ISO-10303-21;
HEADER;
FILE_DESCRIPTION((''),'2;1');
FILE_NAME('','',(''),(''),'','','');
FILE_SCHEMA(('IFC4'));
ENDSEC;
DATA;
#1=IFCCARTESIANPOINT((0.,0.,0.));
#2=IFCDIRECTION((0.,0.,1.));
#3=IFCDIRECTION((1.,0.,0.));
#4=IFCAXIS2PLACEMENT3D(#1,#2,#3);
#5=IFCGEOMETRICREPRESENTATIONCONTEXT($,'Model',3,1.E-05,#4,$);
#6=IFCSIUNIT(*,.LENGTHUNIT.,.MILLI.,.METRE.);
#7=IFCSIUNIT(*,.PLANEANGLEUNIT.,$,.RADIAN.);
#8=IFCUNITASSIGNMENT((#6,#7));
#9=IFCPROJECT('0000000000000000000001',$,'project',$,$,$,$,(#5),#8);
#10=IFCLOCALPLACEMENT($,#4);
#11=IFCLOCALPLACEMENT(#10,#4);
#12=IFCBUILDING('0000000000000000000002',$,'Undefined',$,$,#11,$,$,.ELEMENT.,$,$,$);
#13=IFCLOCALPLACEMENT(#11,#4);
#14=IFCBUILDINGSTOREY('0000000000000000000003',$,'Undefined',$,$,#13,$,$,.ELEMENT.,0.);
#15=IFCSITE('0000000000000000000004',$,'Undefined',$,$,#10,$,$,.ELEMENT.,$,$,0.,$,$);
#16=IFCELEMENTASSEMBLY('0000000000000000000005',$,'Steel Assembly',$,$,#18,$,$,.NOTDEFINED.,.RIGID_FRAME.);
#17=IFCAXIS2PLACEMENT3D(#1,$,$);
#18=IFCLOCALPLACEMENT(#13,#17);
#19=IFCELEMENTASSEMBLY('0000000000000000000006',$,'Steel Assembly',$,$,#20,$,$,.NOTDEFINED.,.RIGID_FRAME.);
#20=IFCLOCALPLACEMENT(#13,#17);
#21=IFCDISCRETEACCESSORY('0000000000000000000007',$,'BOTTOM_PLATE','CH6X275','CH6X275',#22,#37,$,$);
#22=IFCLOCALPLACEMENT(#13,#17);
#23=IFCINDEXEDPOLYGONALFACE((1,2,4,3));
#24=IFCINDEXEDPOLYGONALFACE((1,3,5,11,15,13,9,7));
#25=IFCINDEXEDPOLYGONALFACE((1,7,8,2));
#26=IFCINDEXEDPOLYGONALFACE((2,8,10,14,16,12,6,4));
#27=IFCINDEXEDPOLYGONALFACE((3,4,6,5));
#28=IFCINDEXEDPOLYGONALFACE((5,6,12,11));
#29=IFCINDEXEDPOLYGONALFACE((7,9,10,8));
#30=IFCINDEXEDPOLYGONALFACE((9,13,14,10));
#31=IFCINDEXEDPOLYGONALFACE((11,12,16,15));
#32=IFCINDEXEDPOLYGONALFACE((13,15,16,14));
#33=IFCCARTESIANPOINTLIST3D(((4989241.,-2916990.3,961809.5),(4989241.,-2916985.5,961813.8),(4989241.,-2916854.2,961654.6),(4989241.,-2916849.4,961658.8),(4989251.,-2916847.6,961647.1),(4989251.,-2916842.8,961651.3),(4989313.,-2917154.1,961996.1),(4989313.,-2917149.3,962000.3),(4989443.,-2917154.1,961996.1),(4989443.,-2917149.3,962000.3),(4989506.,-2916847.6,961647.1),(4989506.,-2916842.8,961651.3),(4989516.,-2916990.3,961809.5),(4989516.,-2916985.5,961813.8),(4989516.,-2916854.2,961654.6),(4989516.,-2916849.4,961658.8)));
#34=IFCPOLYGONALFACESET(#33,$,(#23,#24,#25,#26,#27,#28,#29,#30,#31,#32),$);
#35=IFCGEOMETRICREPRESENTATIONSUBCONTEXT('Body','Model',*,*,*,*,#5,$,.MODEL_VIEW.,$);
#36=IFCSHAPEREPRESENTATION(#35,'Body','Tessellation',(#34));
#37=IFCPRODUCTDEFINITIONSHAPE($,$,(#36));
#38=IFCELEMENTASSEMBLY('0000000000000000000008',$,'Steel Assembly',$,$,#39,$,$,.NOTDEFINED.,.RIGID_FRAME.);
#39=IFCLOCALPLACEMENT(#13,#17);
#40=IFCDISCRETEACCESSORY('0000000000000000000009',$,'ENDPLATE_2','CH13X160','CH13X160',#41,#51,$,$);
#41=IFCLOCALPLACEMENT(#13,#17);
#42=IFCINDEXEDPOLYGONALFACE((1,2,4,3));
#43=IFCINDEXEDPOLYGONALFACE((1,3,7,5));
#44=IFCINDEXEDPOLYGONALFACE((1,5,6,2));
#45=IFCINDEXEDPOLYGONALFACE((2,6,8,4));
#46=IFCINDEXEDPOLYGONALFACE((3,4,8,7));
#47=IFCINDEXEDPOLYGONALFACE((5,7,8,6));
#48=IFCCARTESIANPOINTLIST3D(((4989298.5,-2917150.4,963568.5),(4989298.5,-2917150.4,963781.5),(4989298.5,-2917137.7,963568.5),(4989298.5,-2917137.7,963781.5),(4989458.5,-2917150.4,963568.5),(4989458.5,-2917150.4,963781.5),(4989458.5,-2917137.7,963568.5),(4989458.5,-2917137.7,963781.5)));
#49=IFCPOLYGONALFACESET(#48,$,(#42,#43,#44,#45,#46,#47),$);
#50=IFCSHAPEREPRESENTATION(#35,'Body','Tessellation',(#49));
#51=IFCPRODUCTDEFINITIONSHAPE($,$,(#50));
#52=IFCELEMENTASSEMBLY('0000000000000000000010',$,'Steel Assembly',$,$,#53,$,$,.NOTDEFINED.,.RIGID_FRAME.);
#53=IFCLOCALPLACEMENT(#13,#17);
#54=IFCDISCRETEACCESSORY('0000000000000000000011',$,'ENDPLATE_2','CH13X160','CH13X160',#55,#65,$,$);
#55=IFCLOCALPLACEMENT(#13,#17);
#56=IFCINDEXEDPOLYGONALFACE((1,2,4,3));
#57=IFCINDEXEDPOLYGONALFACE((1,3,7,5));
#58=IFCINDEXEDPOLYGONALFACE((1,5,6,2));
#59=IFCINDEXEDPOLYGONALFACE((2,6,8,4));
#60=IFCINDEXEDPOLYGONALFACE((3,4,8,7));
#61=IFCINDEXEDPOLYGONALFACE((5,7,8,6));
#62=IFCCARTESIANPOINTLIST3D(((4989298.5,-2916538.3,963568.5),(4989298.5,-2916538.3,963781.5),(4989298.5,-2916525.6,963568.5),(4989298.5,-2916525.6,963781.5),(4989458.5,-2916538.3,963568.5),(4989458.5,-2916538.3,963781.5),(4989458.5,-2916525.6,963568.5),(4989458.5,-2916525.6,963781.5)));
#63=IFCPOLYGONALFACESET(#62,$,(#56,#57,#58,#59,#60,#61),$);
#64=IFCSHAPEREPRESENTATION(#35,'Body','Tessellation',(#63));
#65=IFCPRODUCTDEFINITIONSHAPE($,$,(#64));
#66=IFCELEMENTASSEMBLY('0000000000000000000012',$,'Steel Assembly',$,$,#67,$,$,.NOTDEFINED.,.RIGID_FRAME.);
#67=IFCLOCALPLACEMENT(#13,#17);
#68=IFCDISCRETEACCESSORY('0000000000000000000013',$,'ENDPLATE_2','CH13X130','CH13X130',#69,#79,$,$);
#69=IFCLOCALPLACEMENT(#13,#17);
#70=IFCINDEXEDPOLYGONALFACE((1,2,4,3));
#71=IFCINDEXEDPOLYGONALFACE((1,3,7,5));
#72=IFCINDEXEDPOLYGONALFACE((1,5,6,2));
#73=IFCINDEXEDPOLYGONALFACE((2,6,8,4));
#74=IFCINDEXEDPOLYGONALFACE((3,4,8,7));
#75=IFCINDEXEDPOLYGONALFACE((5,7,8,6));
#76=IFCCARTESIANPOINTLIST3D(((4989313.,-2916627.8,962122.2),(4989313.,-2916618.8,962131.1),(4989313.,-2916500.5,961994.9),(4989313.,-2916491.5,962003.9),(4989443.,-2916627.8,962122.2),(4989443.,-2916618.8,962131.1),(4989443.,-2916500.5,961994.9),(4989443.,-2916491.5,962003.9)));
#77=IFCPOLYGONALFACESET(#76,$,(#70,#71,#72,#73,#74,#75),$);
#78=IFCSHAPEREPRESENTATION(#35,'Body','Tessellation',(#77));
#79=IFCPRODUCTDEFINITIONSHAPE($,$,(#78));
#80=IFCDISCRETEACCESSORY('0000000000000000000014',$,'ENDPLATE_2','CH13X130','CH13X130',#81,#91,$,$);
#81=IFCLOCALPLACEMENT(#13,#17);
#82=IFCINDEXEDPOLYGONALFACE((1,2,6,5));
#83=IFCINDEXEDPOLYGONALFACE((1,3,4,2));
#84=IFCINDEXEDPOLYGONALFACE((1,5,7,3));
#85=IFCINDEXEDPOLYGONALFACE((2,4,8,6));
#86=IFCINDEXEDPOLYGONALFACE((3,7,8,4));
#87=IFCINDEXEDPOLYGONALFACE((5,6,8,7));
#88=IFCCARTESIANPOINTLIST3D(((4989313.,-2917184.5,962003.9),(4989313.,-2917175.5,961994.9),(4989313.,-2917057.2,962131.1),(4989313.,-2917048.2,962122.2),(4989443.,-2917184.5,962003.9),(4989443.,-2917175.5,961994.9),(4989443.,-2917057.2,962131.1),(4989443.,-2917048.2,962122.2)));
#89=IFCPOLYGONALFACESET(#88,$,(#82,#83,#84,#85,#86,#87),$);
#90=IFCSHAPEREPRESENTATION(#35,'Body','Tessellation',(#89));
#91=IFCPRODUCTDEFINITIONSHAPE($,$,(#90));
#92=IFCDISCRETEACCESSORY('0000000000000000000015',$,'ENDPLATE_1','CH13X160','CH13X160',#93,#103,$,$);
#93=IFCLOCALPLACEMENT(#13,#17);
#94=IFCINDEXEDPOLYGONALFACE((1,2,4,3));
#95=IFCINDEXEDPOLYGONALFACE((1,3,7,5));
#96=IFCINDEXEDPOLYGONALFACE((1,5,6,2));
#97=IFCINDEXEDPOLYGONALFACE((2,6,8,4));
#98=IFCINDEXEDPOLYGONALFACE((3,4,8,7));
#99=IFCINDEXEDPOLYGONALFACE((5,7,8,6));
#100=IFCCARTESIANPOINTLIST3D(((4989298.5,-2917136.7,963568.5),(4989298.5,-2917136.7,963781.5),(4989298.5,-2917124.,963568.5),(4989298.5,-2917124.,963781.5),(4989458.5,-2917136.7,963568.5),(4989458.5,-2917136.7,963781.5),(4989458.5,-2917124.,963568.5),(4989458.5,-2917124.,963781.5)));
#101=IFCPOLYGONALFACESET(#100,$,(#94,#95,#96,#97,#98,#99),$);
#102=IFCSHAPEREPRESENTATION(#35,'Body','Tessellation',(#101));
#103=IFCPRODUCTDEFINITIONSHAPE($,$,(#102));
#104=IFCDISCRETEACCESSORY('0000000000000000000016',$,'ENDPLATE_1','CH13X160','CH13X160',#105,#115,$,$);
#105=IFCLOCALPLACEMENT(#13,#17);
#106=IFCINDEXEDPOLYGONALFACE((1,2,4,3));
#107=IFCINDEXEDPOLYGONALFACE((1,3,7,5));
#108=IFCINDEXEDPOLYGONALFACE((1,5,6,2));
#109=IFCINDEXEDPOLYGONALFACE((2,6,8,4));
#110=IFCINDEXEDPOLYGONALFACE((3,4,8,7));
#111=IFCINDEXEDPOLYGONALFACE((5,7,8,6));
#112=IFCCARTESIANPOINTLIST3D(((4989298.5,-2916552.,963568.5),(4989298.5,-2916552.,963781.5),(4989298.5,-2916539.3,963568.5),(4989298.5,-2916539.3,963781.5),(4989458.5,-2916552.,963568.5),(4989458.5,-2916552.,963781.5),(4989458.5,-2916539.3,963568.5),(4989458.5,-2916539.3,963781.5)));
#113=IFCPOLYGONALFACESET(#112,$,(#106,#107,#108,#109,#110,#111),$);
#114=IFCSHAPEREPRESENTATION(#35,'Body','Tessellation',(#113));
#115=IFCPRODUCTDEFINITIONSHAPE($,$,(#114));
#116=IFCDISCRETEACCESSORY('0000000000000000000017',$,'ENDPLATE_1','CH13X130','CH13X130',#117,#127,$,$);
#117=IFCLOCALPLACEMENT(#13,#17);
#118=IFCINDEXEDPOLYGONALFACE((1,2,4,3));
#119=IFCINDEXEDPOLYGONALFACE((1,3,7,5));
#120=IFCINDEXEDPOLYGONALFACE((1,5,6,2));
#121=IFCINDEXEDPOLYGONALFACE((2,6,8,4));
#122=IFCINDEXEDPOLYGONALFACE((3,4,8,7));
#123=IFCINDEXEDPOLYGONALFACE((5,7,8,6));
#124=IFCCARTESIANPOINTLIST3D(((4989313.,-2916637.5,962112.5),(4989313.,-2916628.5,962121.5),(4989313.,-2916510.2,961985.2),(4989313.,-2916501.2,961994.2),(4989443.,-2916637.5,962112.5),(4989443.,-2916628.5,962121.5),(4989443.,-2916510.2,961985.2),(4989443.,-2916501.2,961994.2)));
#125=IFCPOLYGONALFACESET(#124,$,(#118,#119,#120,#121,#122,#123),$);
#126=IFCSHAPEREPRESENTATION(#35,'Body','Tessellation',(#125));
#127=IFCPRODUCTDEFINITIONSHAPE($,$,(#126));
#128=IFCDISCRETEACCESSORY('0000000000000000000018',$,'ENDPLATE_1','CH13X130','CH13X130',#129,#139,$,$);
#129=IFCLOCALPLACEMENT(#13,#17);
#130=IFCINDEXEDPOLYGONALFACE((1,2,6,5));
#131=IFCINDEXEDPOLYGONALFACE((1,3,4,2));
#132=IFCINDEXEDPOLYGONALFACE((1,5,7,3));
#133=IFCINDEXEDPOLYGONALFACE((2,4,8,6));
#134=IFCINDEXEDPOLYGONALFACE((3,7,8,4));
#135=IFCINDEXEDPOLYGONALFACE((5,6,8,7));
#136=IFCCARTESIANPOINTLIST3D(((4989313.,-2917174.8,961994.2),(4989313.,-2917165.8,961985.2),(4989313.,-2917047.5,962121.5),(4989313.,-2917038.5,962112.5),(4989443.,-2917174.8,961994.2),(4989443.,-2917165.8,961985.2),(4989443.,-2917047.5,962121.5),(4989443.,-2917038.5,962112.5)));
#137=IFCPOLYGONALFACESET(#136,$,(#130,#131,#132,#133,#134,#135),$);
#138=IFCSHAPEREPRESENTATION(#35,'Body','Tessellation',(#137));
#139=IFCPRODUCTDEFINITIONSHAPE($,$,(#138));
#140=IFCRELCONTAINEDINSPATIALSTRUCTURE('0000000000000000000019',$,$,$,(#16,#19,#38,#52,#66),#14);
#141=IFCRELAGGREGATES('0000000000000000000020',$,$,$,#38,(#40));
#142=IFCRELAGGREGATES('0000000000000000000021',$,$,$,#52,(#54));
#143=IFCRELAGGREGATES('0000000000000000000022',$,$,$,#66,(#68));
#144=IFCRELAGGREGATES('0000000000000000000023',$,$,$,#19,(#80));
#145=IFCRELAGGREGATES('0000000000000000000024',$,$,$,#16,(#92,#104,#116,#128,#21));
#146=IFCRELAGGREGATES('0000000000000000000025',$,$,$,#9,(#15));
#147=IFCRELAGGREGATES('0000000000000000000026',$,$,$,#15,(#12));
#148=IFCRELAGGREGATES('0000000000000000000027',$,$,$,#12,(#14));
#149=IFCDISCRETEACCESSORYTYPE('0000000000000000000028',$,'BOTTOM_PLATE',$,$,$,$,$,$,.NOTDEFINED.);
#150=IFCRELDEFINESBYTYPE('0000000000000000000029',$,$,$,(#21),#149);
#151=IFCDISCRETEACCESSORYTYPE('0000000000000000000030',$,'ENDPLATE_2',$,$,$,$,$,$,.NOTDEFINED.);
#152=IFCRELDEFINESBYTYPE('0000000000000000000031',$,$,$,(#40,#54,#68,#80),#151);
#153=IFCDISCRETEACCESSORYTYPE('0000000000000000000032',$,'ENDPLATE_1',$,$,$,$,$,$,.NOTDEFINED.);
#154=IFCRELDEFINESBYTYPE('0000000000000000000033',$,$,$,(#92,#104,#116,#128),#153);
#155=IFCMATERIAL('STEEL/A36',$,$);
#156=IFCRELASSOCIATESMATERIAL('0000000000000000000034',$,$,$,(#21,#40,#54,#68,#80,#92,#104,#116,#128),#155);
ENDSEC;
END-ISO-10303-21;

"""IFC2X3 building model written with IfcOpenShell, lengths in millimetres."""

from ifc_helpers import new_model, si_unit, frame, origin_with_axes, place, context, subcontext, project, spatial, polyline, outline, extrude, material, type_object, element, aggregate, save


model = new_model("IFC2X3")

# Units and contexts
model_context = context("Model", 3, precision=1e-05, world=origin_with_axes())
body_context = subcontext(model_context, "Body", "Model", "MODEL_VIEW")
ifc_project = project(units=[si_unit("LENGTHUNIT", "METRE", prefix="MILLI"), si_unit("PLANEANGLEUNIT", "RADIAN")], contexts=[model_context])

# Site, building, storey
site_placement = place(None, origin_with_axes())
site = spatial("IfcSite", under=ifc_project, at=site_placement, Name="Undefined", CompositionType="ELEMENT", RefElevation=0.0)
building_placement = place(site_placement, origin_with_axes())
building = spatial("IfcBuilding", under=site, at=building_placement, Name="Undefined", CompositionType="ELEMENT")
storey_placement = place(building_placement, origin_with_axes())
storey = spatial("IfcBuildingStorey", under=building, at=storey_placement, Name="Undefined", CompositionType="ELEMENT", Elevation=0.0)

# Element assembly
assembly_1_placement = place(storey_placement, origin_with_axes())
assembly_1 = element("IfcElementAssembly", 1, at=assembly_1_placement, inside=storey, Name="Steel Assembly", AssemblyPlace="NOTDEFINED", PredefinedType="RIGID_FRAME")

# Element assembly
assembly_2_placement = place(storey_placement, origin_with_axes())
assembly_2 = element("IfcElementAssembly", 2, at=assembly_2_placement, inside=storey, Name="Steel Assembly", AssemblyPlace="NOTDEFINED", PredefinedType="RIGID_FRAME")
ifc_material_1 = material(Name="STEEL/A36")

# Discrete accessory
discrete_accessory_type_1 = type_object("IfcDiscreteAccessoryType", Name="BOTTOM_PLATE")
discrete_accessory_1_placement = place(assembly_1_placement, frame((4989516.0, -2916987.9, 961811.6), z_axis=(0.0, 0.75135, 0.659903), x_axis=(0.0, 0.659903, -0.75135)))
discrete_accessory_1 = element("IfcDiscreteAccessory", 3, at=discrete_accessory_1_placement, type_object=discrete_accessory_type_1, material=ifc_material_1, Name="BOTTOM_PLATE", Description="CH6X275", ObjectType="CH6X275", context=body_context, shape_type="SweptSolid", body=[
    extrude(outline(polyline([(0.0, 0.0), (206.2, 0.0), (216.2, 10.0), (216.2, 265.0), (206.2, 275.0), (0.0, 275.0), (-248.3, 203.0), (-248.3, 73.0), (0.0, 0.0)])), frame((0.0, 0.0, -3.2), z_axis=(0.0, 0.0, 1.0), x_axis=(1.0, 0.0, 0.0)), (0.0, 0.0, 1.0), 6.4),
])

# Element assemblies, discrete accessories
assembly_3_placement = place(storey_placement, origin_with_axes())
assembly_3 = element("IfcElementAssembly", 4, at=assembly_3_placement, inside=storey, Name="Steel Assembly", AssemblyPlace="NOTDEFINED", PredefinedType="RIGID_FRAME")
discrete_accessory_type_2 = type_object("IfcDiscreteAccessoryType", Name="ENDPLATE_2")
discrete_accessory_2_placement = place(assembly_3_placement, frame((4989458.5, -2917144.1, 963568.5), z_axis=(0.0, -1.0, 0.0), x_axis=(0.0, 0.0, 1.0)))
discrete_accessory_2 = element("IfcDiscreteAccessory", 5, at=discrete_accessory_2_placement, type_object=discrete_accessory_type_2, material=ifc_material_1, Name="ENDPLATE_2", Description="CH13X160", ObjectType="CH13X160", context=body_context, shape_type="SweptSolid", body=[
    extrude(outline(polyline([(0.0, 0.0), (213.0, 0.0), (213.0, 160.0), (0.0, 160.0), (0.0, 0.0)])), frame((0.0, 0.0, -6.3), z_axis=(0.0, 0.0, 1.0), x_axis=(1.0, 0.0, 0.0)), (0.0, 0.0, 1.0), 12.7),
])
aggregate(assembly_3, [discrete_accessory_2])
assembly_4_placement = place(storey_placement, origin_with_axes())
assembly_4 = element("IfcElementAssembly", 6, at=assembly_4_placement, inside=storey, Name="Steel Assembly", AssemblyPlace="NOTDEFINED", PredefinedType="RIGID_FRAME")
discrete_accessory_3_placement = place(assembly_4_placement, frame((4989298.5, -2916532.0, 963568.5), z_axis=(0.0, 1.0, 0.0), x_axis=(0.0, 0.0, 1.0)))
discrete_accessory_3 = element("IfcDiscreteAccessory", 7, at=discrete_accessory_3_placement, type_object=discrete_accessory_type_2, material=ifc_material_1, Name="ENDPLATE_2", Description="CH13X160", ObjectType="CH13X160", context=body_context, shape_type="SweptSolid", body=[
    extrude(outline(polyline([(0.0, 0.0), (213.0, 0.0), (213.0, 160.0), (0.0, 160.0), (0.0, 0.0)])), frame((0.0, 0.0, -6.3), z_axis=(0.0, 0.0, 1.0), x_axis=(1.0, 0.0, 0.0)), (0.0, 0.0, 1.0), 12.7),
])
aggregate(assembly_4, [discrete_accessory_3])
assembly_5_placement = place(storey_placement, origin_with_axes())
assembly_5 = element("IfcElementAssembly", 8, at=assembly_5_placement, inside=storey, Name="Steel Assembly", AssemblyPlace="NOTDEFINED", PredefinedType="RIGID_FRAME")
discrete_accessory_4_placement = place(assembly_5_placement, frame((4989443.0, -2916496.0, 961999.4), z_axis=(0.0, -0.707107, -0.707107), x_axis=(0.0, -0.707107, 0.707107)))
discrete_accessory_4 = element("IfcDiscreteAccessory", 9, at=discrete_accessory_4_placement, type_object=discrete_accessory_type_2, material=ifc_material_1, Name="ENDPLATE_2", Description="CH13X130", ObjectType="CH13X130", context=body_context, shape_type="SweptSolid", body=[
    extrude(outline(polyline([(0.0, 0.0), (180.0, 0.0), (180.0, 130.0), (0.0, 130.0), (0.0, 0.0)])), frame((0.0, 0.0, -6.3), z_axis=(0.0, 0.0, 1.0), x_axis=(1.0, 0.0, 0.0)), (0.0, 0.0, 1.0), 12.7),
])
aggregate(assembly_5, [discrete_accessory_4])

# Discrete accessories
discrete_accessory_5_placement = place(assembly_2_placement, frame((4989443.0, -2917180.0, 961999.4), z_axis=(0.0, -0.707107, 0.707107), x_axis=(0.0, 0.707107, 0.707107)))
discrete_accessory_5 = element("IfcDiscreteAccessory", 10, at=discrete_accessory_5_placement, type_object=discrete_accessory_type_2, material=ifc_material_1, Name="ENDPLATE_2", Description="CH13X130", ObjectType="CH13X130", context=body_context, shape_type="SweptSolid", body=[
    extrude(outline(polyline([(0.0, 0.0), (180.0, 0.0), (180.0, 130.0), (0.0, 130.0), (0.0, 0.0)])), frame((0.0, 0.0, -6.3), z_axis=(0.0, 0.0, 1.0), x_axis=(1.0, 0.0, 0.0)), (0.0, 0.0, 1.0), 12.7),
])
aggregate(assembly_2, [discrete_accessory_5])
discrete_accessory_type_3 = type_object("IfcDiscreteAccessoryType", Name="ENDPLATE_1")
discrete_accessory_6_placement = place(assembly_1_placement, frame((4989458.5, -2917130.4, 963568.5), z_axis=(0.0, -1.0, 0.0), x_axis=(0.0, 0.0, 1.0)))
discrete_accessory_6 = element("IfcDiscreteAccessory", 11, at=discrete_accessory_6_placement, type_object=discrete_accessory_type_3, material=ifc_material_1, Name="ENDPLATE_1", Description="CH13X160", ObjectType="CH13X160", context=body_context, shape_type="SweptSolid", body=[
    extrude(outline(polyline([(0.0, 0.0), (213.0, 0.0), (213.0, 160.0), (0.0, 160.0), (0.0, 0.0)])), frame((0.0, 0.0, -6.3), z_axis=(0.0, 0.0, 1.0), x_axis=(1.0, 0.0, 0.0)), (0.0, 0.0, 1.0), 12.7),
])
discrete_accessory_7_placement = place(assembly_1_placement, frame((4989298.5, -2916545.7, 963568.5), z_axis=(0.0, 1.0, 0.0), x_axis=(0.0, 0.0, 1.0)))
discrete_accessory_7 = element("IfcDiscreteAccessory", 12, at=discrete_accessory_7_placement, type_object=discrete_accessory_type_3, material=ifc_material_1, Name="ENDPLATE_1", Description="CH13X160", ObjectType="CH13X160", context=body_context, shape_type="SweptSolid", body=[
    extrude(outline(polyline([(0.0, 0.0), (213.0, 0.0), (213.0, 160.0), (0.0, 160.0), (0.0, 0.0)])), frame((0.0, 0.0, -6.3), z_axis=(0.0, 0.0, 1.0), x_axis=(1.0, 0.0, 0.0)), (0.0, 0.0, 1.0), 12.7),
])
discrete_accessory_8_placement = place(assembly_1_placement, frame((4989443.0, -2916505.7, 961989.7), z_axis=(0.0, -0.707107, -0.707107), x_axis=(0.0, -0.707107, 0.707107)))
discrete_accessory_8 = element("IfcDiscreteAccessory", 13, at=discrete_accessory_8_placement, type_object=discrete_accessory_type_3, material=ifc_material_1, Name="ENDPLATE_1", Description="CH13X130", ObjectType="CH13X130", context=body_context, shape_type="SweptSolid", body=[
    extrude(outline(polyline([(0.0, 0.0), (180.0, 0.0), (180.0, 130.0), (0.0, 130.0), (0.0, 0.0)])), frame((0.0, 0.0, -6.3), z_axis=(0.0, 0.0, 1.0), x_axis=(1.0, 0.0, 0.0)), (0.0, 0.0, 1.0), 12.7),
])
discrete_accessory_9_placement = place(assembly_1_placement, frame((4989443.0, -2917170.3, 961989.7), z_axis=(0.0, -0.707107, 0.707107), x_axis=(0.0, 0.707107, 0.707107)))
discrete_accessory_9 = element("IfcDiscreteAccessory", 14, at=discrete_accessory_9_placement, type_object=discrete_accessory_type_3, material=ifc_material_1, Name="ENDPLATE_1", Description="CH13X130", ObjectType="CH13X130", context=body_context, shape_type="SweptSolid", body=[
    extrude(outline(polyline([(0.0, 0.0), (180.0, 0.0), (180.0, 130.0), (0.0, 130.0), (0.0, 0.0)])), frame((0.0, 0.0, -6.3), z_axis=(0.0, 0.0, 1.0), x_axis=(1.0, 0.0, 0.0)), (0.0, 0.0, 1.0), 12.7),
])
aggregate(assembly_1, [discrete_accessory_6, discrete_accessory_7, discrete_accessory_8, discrete_accessory_9, discrete_accessory_1])

save(model, "model.ifc")
